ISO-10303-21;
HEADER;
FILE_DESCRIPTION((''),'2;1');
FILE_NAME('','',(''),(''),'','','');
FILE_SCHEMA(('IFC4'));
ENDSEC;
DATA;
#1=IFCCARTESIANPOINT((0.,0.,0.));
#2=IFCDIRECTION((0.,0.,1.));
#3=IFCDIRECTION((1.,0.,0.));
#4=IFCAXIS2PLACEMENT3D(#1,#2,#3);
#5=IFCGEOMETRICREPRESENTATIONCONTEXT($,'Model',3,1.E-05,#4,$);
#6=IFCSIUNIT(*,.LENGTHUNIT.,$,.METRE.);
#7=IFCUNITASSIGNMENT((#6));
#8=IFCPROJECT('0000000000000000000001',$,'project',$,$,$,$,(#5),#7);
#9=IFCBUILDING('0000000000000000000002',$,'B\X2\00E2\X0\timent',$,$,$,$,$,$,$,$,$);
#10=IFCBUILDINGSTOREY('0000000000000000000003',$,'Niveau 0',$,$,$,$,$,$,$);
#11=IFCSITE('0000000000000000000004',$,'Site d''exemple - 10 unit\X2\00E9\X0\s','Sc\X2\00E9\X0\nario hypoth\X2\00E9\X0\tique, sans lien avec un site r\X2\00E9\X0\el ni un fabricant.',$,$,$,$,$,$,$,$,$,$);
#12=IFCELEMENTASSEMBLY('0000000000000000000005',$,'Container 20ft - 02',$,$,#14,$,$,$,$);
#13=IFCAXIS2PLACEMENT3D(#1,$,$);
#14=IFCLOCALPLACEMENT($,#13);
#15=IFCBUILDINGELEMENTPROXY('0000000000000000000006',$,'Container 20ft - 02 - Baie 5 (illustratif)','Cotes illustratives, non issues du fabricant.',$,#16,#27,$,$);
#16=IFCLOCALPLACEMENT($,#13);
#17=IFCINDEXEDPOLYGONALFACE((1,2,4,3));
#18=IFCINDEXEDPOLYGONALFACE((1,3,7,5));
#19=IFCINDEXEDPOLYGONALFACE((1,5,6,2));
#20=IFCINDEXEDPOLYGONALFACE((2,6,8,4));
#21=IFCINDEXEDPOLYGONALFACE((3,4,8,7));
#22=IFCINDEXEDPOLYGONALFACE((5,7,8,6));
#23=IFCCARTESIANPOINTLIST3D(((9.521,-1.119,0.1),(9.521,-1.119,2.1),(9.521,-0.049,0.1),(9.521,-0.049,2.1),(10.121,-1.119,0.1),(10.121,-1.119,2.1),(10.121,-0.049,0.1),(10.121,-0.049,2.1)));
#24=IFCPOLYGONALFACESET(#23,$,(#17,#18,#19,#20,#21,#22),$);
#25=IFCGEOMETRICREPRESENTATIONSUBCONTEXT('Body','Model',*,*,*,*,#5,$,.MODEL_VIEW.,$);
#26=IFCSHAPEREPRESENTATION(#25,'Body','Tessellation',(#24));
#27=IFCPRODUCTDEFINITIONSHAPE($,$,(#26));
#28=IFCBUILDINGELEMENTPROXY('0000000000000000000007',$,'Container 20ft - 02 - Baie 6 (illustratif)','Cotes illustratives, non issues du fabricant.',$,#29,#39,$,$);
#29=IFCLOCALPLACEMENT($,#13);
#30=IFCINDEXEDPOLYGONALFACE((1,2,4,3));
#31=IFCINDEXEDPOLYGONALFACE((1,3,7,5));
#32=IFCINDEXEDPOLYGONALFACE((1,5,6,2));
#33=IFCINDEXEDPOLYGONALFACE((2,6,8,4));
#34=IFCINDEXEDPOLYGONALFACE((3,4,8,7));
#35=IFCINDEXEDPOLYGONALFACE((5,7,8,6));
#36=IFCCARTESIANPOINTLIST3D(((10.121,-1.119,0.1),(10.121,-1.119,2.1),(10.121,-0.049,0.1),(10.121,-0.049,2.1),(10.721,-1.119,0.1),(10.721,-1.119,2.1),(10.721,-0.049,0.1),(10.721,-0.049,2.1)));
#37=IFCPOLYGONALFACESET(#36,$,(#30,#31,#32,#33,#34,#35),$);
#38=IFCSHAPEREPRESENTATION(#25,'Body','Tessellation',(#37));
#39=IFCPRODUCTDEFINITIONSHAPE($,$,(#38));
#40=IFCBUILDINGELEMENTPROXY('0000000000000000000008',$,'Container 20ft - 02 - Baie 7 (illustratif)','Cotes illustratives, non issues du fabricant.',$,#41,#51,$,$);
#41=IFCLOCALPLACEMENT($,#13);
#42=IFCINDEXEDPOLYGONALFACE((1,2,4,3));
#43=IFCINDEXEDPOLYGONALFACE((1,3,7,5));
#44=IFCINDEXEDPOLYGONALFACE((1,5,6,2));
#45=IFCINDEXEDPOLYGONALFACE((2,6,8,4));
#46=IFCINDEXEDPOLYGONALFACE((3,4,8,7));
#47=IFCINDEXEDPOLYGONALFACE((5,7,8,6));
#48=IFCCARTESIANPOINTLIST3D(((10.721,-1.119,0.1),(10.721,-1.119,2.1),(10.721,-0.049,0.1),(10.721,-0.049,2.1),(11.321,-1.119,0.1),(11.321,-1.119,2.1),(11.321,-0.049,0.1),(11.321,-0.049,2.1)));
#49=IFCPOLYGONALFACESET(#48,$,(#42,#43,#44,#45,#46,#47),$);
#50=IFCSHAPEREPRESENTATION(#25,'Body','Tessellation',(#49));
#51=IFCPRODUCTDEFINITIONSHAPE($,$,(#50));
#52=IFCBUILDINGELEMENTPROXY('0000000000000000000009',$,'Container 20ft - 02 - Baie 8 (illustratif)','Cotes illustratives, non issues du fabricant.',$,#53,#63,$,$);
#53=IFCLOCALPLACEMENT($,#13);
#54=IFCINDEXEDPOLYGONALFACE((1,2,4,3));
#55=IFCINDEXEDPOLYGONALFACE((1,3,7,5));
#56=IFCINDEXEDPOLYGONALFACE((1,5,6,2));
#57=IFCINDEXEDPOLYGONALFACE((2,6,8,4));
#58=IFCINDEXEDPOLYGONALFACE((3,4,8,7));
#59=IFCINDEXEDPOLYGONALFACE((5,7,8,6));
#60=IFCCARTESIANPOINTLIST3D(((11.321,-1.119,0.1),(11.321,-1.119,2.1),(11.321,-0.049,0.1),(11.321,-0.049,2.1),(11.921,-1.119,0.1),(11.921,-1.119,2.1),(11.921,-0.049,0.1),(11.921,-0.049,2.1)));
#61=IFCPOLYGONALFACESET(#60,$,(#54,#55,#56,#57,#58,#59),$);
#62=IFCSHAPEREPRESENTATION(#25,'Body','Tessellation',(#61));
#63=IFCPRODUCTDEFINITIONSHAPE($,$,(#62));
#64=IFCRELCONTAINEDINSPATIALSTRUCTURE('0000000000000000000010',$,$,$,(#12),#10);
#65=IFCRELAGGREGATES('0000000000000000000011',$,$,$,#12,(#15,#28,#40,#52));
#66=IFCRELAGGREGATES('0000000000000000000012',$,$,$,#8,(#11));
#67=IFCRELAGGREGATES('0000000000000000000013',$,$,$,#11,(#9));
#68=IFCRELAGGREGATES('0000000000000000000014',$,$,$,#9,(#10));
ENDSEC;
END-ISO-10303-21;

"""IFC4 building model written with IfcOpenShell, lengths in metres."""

from ifc_helpers import new_model, si_unit, frame, origin_with_axes, place, context, subcontext, project, spatial, rectangle, extrude, element, aggregate, save


model = new_model("IFC4")

# Units and contexts
model_context = context("Model", 3, precision=1e-05, world=origin_with_axes())
body_context = subcontext(model_context, "Body", "Model", "MODEL_VIEW")
ifc_project = project(units=[si_unit("LENGTHUNIT", "METRE")], contexts=[model_context])

# Site, building, storey
site = spatial("IfcSite", under=ifc_project, Name="Site d'exemple - 10 unités", Description="Scénario hypothétique, sans lien avec un site réel ni un fabricant.")
building = spatial("IfcBuilding", under=site, Name="Bâtiment")
storey = spatial("IfcBuildingStorey", under=building, Name="Niveau 0")

# Element assembly, building element proxies
assembly = element("IfcElementAssembly", 1, inside=storey, Name="Container 20ft - 02")
proxy_1_placement = place(None, frame((9.821, -0.584, 0.1), z_axis=(0.0, 0.0, 1.0), x_axis=(1.0, 0.0, 0.0)))
proxy_1 = element("IfcBuildingElementProxy", 2, at=proxy_1_placement, Name="Container 20ft - 02 - Baie 5 (illustratif)", Description="Cotes illustratives, non issues du fabricant.", context=body_context, shape_type="SweptSolid", body=[
    extrude(rectangle(XDim=0.6, YDim=1.07), origin_with_axes(), (0.0, 0.0, 1.0), 2.0),
])
proxy_2_placement = place(None, frame((10.421, -0.584, 0.1), z_axis=(0.0, 0.0, 1.0), x_axis=(1.0, 0.0, 0.0)))
proxy_2 = element("IfcBuildingElementProxy", 3, at=proxy_2_placement, Name="Container 20ft - 02 - Baie 6 (illustratif)", Description="Cotes illustratives, non issues du fabricant.", context=body_context, shape_type="SweptSolid", body=[
    extrude(rectangle(XDim=0.6, YDim=1.07), origin_with_axes(), (0.0, 0.0, 1.0), 2.0),
])
proxy_3_placement = place(None, frame((11.021, -0.584, 0.1), z_axis=(0.0, 0.0, 1.0), x_axis=(1.0, 0.0, 0.0)))
proxy_3 = element("IfcBuildingElementProxy", 4, at=proxy_3_placement, Name="Container 20ft - 02 - Baie 7 (illustratif)", Description="Cotes illustratives, non issues du fabricant.", context=body_context, shape_type="SweptSolid", body=[
    extrude(rectangle(XDim=0.6, YDim=1.07), origin_with_axes(), (0.0, 0.0, 1.0), 2.0),
])
proxy_4_placement = place(None, frame((11.621, -0.584, 0.1), z_axis=(0.0, 0.0, 1.0), x_axis=(1.0, 0.0, 0.0)))
proxy_4 = element("IfcBuildingElementProxy", 5, at=proxy_4_placement, Name="Container 20ft - 02 - Baie 8 (illustratif)", Description="Cotes illustratives, non issues du fabricant.", context=body_context, shape_type="SweptSolid", body=[
    extrude(rectangle(XDim=0.6, YDim=1.07), origin_with_axes(), (0.0, 0.0, 1.0), 2.0),
])
aggregate(assembly, [proxy_1, proxy_2, proxy_3, proxy_4])

save(model, "model.ifc")
